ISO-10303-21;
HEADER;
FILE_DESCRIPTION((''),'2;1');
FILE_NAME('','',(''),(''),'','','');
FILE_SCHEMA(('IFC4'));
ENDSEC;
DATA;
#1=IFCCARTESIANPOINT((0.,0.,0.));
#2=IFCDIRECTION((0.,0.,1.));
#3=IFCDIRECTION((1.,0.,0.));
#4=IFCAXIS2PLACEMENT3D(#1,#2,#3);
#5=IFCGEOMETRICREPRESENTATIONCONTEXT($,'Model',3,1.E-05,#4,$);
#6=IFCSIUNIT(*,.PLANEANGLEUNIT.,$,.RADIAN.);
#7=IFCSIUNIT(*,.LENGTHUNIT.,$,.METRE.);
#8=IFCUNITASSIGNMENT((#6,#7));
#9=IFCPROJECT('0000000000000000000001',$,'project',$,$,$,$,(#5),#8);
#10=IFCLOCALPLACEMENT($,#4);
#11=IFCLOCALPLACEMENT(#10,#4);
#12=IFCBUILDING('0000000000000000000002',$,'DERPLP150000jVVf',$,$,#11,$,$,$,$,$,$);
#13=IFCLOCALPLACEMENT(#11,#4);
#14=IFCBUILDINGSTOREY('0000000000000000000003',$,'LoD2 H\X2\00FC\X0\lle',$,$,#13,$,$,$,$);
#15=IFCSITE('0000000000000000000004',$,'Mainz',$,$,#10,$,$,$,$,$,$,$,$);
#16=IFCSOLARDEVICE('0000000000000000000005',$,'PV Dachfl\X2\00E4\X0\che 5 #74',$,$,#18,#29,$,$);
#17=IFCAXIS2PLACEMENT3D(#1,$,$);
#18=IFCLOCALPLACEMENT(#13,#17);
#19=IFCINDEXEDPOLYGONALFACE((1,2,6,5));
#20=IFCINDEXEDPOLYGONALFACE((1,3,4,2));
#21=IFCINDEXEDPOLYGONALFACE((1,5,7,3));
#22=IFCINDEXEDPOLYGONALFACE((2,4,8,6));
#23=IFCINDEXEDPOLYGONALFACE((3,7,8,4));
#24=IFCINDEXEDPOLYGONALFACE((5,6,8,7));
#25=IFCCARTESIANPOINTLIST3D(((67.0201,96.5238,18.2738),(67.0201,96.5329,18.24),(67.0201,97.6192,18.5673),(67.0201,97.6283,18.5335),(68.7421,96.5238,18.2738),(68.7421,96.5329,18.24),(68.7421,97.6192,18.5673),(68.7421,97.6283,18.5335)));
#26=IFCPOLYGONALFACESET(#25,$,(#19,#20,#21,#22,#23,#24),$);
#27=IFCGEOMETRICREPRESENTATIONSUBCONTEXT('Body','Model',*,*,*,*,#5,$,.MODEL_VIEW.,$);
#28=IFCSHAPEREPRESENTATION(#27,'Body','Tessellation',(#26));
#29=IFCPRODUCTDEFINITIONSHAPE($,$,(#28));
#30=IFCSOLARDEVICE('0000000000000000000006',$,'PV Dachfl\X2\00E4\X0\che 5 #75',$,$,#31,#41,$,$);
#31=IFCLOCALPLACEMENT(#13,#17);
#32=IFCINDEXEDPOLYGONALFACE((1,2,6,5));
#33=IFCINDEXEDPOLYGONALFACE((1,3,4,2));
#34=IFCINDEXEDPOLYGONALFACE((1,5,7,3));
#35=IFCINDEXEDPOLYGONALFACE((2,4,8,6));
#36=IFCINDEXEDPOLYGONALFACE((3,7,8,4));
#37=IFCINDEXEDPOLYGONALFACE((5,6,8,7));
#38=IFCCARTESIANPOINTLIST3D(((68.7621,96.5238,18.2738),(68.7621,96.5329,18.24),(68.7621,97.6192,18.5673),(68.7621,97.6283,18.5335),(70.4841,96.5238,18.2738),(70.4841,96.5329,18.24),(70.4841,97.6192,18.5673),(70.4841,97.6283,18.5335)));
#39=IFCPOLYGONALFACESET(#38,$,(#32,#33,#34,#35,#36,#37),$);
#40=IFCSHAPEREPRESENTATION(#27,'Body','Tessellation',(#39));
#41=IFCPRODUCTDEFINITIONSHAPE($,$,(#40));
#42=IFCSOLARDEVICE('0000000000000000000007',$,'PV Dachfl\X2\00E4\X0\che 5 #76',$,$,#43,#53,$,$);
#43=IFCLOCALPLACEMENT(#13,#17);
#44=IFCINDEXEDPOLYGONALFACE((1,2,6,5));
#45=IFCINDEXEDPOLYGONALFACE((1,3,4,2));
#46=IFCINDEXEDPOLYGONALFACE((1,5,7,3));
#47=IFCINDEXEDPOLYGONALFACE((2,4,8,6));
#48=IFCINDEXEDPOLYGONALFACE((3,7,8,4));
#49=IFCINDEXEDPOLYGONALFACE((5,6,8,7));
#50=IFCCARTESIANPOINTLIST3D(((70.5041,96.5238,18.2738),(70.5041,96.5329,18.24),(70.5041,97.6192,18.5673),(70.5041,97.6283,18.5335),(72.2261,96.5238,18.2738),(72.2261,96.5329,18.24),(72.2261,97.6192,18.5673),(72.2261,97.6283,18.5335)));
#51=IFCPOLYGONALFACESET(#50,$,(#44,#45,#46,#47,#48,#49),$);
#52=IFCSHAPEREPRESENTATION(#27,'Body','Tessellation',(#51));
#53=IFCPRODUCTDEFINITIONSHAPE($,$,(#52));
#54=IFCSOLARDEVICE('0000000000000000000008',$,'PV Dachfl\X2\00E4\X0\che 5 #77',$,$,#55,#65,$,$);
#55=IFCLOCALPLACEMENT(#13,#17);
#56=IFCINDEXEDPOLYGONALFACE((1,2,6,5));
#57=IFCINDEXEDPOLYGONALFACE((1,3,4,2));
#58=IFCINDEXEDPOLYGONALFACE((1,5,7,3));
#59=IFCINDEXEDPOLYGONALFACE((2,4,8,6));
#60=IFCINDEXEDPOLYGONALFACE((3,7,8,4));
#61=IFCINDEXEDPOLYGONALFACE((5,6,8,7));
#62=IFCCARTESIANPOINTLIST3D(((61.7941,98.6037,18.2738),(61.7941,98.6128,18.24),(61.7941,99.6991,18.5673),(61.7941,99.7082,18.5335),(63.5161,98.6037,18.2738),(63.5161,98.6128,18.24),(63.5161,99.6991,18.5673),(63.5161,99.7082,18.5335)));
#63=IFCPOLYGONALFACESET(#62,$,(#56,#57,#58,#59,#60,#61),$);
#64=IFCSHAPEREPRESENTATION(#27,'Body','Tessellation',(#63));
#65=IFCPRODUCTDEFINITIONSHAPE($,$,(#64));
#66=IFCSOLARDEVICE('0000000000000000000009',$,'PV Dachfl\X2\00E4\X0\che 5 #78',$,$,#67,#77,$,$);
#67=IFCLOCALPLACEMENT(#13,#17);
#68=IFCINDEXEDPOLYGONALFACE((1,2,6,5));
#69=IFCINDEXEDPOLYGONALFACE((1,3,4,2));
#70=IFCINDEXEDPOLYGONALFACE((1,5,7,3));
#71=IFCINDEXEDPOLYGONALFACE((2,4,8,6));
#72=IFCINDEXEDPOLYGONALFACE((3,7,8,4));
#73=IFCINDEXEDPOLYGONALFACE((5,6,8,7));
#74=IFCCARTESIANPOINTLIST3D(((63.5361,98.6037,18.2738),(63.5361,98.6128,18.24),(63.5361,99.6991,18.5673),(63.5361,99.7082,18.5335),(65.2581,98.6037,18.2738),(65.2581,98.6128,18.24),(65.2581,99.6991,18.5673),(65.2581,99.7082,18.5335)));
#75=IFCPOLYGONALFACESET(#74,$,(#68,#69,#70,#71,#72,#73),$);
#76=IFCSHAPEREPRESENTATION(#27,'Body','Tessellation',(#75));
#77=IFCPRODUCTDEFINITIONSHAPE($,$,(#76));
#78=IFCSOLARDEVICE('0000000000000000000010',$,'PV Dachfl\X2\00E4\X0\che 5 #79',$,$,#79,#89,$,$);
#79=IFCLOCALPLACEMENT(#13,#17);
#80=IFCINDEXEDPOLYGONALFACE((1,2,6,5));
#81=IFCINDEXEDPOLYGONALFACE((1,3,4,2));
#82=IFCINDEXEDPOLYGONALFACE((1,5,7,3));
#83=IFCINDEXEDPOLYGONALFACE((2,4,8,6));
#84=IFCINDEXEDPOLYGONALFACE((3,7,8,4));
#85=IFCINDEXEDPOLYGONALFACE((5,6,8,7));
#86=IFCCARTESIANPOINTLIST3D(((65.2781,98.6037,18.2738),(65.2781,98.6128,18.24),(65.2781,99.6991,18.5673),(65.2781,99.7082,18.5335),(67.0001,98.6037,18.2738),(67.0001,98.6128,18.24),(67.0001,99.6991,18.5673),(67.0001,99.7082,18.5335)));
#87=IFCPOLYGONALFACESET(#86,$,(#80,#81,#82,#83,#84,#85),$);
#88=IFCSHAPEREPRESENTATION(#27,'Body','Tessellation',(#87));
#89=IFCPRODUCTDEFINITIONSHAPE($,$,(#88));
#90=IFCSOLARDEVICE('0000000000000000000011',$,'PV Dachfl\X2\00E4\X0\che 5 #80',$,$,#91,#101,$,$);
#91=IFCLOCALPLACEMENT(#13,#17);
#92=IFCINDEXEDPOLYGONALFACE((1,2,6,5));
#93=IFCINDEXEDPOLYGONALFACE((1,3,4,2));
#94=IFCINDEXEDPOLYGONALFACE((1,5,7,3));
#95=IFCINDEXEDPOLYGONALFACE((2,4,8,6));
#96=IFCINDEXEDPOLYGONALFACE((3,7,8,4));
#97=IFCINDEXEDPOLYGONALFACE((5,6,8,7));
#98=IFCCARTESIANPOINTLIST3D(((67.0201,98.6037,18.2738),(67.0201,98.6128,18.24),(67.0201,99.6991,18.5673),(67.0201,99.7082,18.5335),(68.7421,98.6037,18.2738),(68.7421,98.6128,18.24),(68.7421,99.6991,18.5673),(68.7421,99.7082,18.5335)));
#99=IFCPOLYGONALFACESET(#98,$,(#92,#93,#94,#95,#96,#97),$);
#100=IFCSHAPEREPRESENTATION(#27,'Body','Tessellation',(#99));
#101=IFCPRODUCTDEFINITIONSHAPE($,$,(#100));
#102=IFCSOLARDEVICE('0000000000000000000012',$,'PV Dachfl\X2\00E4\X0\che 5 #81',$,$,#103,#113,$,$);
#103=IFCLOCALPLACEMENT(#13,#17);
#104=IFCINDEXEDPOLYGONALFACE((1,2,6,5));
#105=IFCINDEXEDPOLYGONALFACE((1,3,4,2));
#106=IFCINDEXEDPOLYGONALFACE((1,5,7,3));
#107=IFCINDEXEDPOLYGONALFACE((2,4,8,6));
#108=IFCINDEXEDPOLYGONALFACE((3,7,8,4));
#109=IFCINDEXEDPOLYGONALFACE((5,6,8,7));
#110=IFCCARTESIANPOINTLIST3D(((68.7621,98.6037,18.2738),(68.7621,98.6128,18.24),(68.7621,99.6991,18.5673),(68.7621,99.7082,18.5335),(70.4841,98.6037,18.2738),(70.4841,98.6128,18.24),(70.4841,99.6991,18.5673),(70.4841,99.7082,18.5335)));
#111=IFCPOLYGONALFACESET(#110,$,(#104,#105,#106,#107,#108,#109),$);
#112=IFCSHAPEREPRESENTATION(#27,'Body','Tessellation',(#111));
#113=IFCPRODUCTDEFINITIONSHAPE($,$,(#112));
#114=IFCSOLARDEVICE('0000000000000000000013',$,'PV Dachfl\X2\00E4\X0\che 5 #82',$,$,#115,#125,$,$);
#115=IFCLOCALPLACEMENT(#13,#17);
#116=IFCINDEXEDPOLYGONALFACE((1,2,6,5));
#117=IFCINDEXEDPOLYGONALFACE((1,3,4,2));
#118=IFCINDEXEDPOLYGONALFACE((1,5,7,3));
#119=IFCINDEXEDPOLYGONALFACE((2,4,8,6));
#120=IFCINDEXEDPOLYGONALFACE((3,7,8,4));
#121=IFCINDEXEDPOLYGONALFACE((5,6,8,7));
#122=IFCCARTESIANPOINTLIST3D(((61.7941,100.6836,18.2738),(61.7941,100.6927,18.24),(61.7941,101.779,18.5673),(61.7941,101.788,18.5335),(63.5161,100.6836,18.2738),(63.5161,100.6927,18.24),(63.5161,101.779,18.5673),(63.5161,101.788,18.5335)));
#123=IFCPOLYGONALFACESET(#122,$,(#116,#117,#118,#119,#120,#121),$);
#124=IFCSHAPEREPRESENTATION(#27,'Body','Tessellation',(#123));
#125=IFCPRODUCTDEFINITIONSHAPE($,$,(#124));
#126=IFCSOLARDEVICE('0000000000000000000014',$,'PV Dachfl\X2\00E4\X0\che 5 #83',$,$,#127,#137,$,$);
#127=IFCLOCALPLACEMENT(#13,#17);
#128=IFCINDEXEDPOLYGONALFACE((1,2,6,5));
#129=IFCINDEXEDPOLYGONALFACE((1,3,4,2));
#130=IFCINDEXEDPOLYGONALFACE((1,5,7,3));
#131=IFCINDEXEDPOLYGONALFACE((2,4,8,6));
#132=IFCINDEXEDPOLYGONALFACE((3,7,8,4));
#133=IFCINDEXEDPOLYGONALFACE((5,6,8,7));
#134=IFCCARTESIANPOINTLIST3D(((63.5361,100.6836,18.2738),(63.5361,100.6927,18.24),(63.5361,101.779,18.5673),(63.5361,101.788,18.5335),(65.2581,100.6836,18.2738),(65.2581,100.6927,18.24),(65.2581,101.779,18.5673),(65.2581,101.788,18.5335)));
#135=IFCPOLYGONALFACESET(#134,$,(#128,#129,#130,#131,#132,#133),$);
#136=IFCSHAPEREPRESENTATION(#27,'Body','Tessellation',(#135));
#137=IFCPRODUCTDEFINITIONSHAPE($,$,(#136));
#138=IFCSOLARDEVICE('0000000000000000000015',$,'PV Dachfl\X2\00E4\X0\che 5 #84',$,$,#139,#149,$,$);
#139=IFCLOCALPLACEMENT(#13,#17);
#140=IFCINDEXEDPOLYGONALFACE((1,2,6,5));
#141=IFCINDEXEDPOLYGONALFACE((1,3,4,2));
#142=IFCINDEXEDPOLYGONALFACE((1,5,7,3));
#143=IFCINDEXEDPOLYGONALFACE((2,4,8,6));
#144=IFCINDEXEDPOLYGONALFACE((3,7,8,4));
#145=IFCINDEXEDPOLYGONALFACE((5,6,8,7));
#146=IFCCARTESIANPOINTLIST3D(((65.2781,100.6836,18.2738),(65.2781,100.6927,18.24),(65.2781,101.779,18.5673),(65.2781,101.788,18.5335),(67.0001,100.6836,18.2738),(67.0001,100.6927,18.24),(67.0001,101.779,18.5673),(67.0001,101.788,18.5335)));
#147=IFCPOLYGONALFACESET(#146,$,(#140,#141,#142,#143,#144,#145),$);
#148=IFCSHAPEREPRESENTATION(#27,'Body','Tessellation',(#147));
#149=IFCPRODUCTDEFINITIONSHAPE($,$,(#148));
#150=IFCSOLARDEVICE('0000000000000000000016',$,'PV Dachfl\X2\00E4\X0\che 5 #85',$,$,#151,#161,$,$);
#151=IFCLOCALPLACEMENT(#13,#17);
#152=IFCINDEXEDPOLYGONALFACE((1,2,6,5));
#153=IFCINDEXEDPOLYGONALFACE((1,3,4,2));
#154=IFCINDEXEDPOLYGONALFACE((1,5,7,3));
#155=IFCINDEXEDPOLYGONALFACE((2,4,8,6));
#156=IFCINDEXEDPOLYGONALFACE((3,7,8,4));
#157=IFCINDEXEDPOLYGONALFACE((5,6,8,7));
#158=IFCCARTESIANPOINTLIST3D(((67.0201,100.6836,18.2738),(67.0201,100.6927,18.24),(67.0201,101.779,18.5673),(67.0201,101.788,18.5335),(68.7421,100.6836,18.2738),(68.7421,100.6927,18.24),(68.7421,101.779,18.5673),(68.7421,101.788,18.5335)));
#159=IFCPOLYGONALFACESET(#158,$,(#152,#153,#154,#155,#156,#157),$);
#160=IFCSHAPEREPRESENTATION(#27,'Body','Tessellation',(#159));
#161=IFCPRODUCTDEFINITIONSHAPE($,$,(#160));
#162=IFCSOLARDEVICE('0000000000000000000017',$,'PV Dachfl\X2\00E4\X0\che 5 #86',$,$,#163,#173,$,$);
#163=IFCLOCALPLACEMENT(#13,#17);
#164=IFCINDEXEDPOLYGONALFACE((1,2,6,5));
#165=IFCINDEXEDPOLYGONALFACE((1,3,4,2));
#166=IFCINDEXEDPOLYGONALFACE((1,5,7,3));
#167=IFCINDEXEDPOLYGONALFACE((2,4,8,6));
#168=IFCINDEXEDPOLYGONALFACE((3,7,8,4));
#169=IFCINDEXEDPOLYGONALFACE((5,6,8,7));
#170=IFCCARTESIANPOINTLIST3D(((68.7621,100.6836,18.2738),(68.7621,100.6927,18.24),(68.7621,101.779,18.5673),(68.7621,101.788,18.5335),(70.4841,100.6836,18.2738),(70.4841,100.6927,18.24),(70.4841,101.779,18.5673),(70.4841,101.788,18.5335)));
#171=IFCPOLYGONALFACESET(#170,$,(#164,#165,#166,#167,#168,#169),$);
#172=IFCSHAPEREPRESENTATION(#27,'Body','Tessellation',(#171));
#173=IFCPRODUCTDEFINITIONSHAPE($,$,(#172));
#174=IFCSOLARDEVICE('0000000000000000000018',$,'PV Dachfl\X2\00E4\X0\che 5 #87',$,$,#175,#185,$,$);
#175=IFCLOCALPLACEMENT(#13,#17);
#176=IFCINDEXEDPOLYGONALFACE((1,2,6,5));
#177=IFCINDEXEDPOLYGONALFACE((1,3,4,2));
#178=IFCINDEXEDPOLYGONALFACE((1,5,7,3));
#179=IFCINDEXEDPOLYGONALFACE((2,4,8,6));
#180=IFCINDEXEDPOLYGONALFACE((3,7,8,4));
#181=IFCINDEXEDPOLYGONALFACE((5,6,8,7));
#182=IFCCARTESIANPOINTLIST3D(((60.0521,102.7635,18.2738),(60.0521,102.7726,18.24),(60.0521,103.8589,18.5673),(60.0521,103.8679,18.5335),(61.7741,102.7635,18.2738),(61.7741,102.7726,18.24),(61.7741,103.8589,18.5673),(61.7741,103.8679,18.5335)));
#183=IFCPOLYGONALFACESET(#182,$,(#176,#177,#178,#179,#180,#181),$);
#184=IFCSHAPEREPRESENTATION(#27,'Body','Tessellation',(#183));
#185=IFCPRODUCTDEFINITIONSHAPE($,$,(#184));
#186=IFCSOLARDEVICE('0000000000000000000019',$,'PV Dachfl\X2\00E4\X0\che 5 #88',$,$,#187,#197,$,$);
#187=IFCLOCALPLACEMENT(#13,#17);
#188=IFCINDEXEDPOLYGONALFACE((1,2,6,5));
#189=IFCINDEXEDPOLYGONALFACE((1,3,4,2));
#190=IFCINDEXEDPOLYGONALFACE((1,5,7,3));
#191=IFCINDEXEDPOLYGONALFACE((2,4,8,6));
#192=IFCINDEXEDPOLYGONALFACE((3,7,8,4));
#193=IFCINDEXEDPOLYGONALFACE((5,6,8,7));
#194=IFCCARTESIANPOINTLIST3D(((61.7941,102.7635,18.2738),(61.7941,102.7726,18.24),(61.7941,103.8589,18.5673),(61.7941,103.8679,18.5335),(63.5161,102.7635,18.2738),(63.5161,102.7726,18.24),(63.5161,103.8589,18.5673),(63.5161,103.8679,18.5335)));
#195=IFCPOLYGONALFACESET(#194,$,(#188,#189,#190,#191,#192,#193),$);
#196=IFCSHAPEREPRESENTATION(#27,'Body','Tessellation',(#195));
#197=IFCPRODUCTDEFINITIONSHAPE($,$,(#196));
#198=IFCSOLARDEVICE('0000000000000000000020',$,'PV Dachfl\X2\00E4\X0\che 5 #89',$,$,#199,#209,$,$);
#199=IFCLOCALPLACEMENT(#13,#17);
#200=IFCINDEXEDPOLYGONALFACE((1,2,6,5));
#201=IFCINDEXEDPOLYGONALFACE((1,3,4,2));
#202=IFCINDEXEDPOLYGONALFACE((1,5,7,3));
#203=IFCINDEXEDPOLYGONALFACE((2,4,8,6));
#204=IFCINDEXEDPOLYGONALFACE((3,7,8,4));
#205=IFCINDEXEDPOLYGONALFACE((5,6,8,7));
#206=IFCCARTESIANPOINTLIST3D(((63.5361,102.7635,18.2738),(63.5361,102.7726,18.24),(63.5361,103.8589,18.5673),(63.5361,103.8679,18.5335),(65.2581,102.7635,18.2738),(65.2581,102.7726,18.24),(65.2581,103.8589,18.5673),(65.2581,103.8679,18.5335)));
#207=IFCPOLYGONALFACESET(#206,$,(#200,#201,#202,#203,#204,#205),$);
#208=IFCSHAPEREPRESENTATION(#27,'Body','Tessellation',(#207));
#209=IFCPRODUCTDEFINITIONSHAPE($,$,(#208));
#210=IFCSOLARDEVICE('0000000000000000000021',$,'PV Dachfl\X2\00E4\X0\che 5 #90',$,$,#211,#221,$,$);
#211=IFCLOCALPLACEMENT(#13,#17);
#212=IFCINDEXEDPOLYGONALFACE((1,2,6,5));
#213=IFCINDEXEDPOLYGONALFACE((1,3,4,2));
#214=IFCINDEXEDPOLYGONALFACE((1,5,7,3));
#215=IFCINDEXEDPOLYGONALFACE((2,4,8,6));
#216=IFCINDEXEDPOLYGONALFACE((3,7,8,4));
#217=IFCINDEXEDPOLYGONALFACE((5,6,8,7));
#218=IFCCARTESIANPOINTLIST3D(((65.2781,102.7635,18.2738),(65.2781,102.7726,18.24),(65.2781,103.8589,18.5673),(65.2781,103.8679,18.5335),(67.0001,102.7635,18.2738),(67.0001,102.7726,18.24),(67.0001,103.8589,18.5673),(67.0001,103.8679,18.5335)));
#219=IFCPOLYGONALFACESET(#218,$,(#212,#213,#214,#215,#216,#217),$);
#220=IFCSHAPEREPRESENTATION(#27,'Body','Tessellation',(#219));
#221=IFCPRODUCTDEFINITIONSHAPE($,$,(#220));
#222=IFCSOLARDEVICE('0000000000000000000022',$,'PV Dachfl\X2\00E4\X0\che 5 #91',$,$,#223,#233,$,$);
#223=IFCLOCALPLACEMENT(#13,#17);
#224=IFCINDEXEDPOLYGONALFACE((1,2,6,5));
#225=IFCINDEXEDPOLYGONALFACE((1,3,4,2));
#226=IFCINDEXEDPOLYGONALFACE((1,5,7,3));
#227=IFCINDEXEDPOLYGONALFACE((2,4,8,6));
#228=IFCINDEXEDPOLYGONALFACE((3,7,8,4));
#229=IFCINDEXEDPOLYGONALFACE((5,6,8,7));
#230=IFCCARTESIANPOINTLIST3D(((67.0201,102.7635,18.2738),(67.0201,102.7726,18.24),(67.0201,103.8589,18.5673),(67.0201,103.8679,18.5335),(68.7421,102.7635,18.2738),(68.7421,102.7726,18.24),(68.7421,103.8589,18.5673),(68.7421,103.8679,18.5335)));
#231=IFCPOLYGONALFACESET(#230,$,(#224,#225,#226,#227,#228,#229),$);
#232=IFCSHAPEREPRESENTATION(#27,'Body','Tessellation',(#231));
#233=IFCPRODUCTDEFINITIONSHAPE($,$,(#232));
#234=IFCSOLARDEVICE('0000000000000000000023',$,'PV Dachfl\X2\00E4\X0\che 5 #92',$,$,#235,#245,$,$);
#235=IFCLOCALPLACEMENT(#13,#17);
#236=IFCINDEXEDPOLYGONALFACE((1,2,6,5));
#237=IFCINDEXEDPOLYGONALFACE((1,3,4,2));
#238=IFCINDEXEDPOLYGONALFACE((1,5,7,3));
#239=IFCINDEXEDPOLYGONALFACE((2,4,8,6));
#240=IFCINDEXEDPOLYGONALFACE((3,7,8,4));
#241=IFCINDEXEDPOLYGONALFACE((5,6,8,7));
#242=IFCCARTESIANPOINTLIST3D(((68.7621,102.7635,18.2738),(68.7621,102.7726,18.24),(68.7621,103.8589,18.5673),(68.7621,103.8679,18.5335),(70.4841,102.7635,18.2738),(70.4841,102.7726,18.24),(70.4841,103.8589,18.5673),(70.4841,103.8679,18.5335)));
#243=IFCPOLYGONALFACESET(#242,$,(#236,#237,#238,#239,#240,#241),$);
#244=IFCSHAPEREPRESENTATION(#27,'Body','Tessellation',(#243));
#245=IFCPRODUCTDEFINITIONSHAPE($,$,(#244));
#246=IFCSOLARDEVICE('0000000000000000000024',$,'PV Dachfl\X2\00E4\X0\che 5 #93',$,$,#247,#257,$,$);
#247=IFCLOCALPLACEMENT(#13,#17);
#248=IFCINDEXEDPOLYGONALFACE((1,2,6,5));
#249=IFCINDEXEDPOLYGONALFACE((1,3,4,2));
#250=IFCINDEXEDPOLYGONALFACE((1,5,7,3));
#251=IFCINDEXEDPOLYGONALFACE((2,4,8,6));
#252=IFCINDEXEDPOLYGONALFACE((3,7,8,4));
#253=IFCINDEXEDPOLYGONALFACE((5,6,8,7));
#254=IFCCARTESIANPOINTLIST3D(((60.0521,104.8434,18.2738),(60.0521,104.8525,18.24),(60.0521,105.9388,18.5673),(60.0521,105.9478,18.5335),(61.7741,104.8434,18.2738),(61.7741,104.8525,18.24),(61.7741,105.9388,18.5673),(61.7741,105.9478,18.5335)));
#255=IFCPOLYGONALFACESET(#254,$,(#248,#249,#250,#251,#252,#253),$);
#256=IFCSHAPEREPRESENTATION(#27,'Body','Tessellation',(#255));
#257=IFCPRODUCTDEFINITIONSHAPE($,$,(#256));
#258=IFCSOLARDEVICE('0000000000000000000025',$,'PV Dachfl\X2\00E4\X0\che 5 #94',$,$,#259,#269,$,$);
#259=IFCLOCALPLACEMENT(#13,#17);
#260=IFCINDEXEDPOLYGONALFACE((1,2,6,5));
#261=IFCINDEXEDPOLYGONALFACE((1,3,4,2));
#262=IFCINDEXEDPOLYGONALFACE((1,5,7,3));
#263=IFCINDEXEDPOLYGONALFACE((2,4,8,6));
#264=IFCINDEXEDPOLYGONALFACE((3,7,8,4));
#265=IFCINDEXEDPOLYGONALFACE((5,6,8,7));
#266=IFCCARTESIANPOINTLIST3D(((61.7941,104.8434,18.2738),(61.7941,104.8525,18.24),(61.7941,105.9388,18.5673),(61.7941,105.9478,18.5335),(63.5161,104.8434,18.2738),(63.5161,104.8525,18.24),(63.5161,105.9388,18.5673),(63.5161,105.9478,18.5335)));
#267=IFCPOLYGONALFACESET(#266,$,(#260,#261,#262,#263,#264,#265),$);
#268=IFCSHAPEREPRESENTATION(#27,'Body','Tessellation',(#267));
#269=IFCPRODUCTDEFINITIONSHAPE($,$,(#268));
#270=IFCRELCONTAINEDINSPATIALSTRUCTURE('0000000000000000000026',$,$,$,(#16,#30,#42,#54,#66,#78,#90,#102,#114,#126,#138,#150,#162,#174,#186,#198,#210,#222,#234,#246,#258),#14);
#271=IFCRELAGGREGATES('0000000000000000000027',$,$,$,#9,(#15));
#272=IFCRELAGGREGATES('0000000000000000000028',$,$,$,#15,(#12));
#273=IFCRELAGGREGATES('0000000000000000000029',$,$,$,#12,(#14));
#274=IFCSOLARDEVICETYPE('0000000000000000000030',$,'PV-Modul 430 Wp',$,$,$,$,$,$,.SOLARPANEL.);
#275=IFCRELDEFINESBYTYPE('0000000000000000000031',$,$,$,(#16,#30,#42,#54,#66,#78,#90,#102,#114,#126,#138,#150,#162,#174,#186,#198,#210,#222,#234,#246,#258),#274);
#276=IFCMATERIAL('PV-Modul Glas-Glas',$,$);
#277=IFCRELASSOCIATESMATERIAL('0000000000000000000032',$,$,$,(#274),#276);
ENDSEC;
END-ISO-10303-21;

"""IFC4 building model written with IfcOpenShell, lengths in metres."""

from ifc_helpers import new_model, si_unit, frame, frame_2d, origin, origin_with_axes, place, context, subcontext, project, spatial, rectangle, extrude, source, transform, mapped, material, type_object, type_shapes, element, save


model = new_model("IFC4")

# Units and contexts
model_context = context("Model", 3, precision=1e-05, world=origin_with_axes())
body_context = subcontext(model_context, "Body", "Model", "MODEL_VIEW")
ifc_project = project(units=[si_unit("PLANEANGLEUNIT", "RADIAN"), si_unit("LENGTHUNIT", "METRE")], contexts=[model_context])

# Site, building, storey
site_placement = place(None, origin_with_axes())
site = spatial("IfcSite", under=ifc_project, at=site_placement, Name="Mainz")
building_placement = place(site_placement, origin_with_axes())
building = spatial("IfcBuilding", under=site, at=building_placement, Name="DERPLP150000jVVf")
storey_placement = place(building_placement, origin_with_axes())
storey = spatial("IfcBuildingStorey", under=building, at=storey_placement, Name="LoD2 Hülle")

# Solar devices
ifc_material = material(Name="PV-Modul Glas-Glas")
solar_device_type = type_object("IfcSolarDeviceType", Name="PV-Modul 430 Wp", PredefinedType="SOLARPANEL", material=ifc_material)
shared_shape = source(origin_with_axes(), body_context, "Body", "SweptSolid", [
    extrude(rectangle(XDim=1.722, YDim=1.134, at=frame_2d((0.861, 0.567))), origin(), (0.0, 0.0, 1.0), 0.035),
])
type_shapes(solar_device_type, [shared_shape])
for number, where, z_axis, x_axis, name in (
    (1, (67.0201, 96.5329, 18.24), (0.0, -0.258819, 0.965926), (1.0, 0.0, 0.0), "PV Dachfläche 5 #74"),
    (2, (68.7621, 96.5329, 18.24), (0.0, -0.258819, 0.965926), (1.0, 0.0, 0.0), "PV Dachfläche 5 #75"),
    (3, (70.5041, 96.5329, 18.24), (0.0, -0.258819, 0.965926), (1.0, 0.0, 0.0), "PV Dachfläche 5 #76"),
    (4, (61.7941, 98.6128, 18.24), (0.0, -0.258819, 0.965926), (1.0, 0.0, 0.0), "PV Dachfläche 5 #77"),
    (5, (63.5361, 98.6128, 18.24), (0.0, -0.258819, 0.965926), (1.0, 0.0, 0.0), "PV Dachfläche 5 #78"),
    (6, (65.2781, 98.6128, 18.24), (0.0, -0.258819, 0.965926), (1.0, 0.0, 0.0), "PV Dachfläche 5 #79"),
    (7, (67.0201, 98.6128, 18.24), (0.0, -0.258819, 0.965926), (1.0, 0.0, 0.0), "PV Dachfläche 5 #80"),
    (8, (68.7621, 98.6128, 18.24), (0.0, -0.258819, 0.965926), (1.0, 0.0, 0.0), "PV Dachfläche 5 #81"),
    (9, (61.7941, 100.6927, 18.24), (0.0, -0.258819, 0.965926), (1.0, 0.0, 0.0), "PV Dachfläche 5 #82"),
    (10, (63.5361, 100.6927, 18.24), (0.0, -0.258819, 0.965926), (1.0, 0.0, 0.0), "PV Dachfläche 5 #83"),
    (11, (65.2781, 100.6927, 18.24), (0.0, -0.258819, 0.965926), (1.0, 0.0, 0.0), "PV Dachfläche 5 #84"),
    (12, (67.0201, 100.6927, 18.24), (0.0, -0.258819, 0.965926), (1.0, 0.0, 0.0), "PV Dachfläche 5 #85"),
    (13, (68.7621, 100.6927, 18.24), (0.0, -0.258819, 0.965926), (1.0, 0.0, 0.0), "PV Dachfläche 5 #86"),
    (14, (60.0521, 102.7726, 18.24), (0.0, -0.258819, 0.965926), (1.0, 0.0, 0.0), "PV Dachfläche 5 #87"),
    (15, (61.7941, 102.7726, 18.24), (0.0, -0.258819, 0.965926), (1.0, 0.0, 0.0), "PV Dachfläche 5 #88"),
    (16, (63.5361, 102.7726, 18.24), (0.0, -0.258819, 0.965926), (1.0, 0.0, 0.0), "PV Dachfläche 5 #89"),
    (17, (65.2781, 102.7726, 18.24), (0.0, -0.258819, 0.965926), (1.0, 0.0, 0.0), "PV Dachfläche 5 #90"),
    (18, (67.0201, 102.7726, 18.24), (0.0, -0.258819, 0.965926), (1.0, 0.0, 0.0), "PV Dachfläche 5 #91"),
    (19, (68.7621, 102.7726, 18.24), (0.0, -0.258819, 0.965926), (1.0, 0.0, 0.0), "PV Dachfläche 5 #92"),
    (20, (60.0521, 104.8525, 18.24), (0.0, -0.258819, 0.965926), (1.0, 0.0, 0.0), "PV Dachfläche 5 #93"),
    (21, (61.7941, 104.8525, 18.24), (0.0, -0.258819, 0.965926), (1.0, 0.0, 0.0), "PV Dachfläche 5 #94"),
):
    element("IfcSolarDevice", number, at=place(storey_placement, frame(where, z_axis=z_axis, x_axis=x_axis)), inside=storey, type_object=solar_device_type, Name=name, context=body_context, shape_type="MappedRepresentation", body=[
        mapped(shared_shape, transform((0.0, 0.0, 0.0), x_axis=(1.0, 0.0, 0.0), y_axis=(0.0, 1.0, 0.0), z_axis=(0.0, 0.0, 1.0), scale=1.0)),
    ])

save(model, "model.ifc")
